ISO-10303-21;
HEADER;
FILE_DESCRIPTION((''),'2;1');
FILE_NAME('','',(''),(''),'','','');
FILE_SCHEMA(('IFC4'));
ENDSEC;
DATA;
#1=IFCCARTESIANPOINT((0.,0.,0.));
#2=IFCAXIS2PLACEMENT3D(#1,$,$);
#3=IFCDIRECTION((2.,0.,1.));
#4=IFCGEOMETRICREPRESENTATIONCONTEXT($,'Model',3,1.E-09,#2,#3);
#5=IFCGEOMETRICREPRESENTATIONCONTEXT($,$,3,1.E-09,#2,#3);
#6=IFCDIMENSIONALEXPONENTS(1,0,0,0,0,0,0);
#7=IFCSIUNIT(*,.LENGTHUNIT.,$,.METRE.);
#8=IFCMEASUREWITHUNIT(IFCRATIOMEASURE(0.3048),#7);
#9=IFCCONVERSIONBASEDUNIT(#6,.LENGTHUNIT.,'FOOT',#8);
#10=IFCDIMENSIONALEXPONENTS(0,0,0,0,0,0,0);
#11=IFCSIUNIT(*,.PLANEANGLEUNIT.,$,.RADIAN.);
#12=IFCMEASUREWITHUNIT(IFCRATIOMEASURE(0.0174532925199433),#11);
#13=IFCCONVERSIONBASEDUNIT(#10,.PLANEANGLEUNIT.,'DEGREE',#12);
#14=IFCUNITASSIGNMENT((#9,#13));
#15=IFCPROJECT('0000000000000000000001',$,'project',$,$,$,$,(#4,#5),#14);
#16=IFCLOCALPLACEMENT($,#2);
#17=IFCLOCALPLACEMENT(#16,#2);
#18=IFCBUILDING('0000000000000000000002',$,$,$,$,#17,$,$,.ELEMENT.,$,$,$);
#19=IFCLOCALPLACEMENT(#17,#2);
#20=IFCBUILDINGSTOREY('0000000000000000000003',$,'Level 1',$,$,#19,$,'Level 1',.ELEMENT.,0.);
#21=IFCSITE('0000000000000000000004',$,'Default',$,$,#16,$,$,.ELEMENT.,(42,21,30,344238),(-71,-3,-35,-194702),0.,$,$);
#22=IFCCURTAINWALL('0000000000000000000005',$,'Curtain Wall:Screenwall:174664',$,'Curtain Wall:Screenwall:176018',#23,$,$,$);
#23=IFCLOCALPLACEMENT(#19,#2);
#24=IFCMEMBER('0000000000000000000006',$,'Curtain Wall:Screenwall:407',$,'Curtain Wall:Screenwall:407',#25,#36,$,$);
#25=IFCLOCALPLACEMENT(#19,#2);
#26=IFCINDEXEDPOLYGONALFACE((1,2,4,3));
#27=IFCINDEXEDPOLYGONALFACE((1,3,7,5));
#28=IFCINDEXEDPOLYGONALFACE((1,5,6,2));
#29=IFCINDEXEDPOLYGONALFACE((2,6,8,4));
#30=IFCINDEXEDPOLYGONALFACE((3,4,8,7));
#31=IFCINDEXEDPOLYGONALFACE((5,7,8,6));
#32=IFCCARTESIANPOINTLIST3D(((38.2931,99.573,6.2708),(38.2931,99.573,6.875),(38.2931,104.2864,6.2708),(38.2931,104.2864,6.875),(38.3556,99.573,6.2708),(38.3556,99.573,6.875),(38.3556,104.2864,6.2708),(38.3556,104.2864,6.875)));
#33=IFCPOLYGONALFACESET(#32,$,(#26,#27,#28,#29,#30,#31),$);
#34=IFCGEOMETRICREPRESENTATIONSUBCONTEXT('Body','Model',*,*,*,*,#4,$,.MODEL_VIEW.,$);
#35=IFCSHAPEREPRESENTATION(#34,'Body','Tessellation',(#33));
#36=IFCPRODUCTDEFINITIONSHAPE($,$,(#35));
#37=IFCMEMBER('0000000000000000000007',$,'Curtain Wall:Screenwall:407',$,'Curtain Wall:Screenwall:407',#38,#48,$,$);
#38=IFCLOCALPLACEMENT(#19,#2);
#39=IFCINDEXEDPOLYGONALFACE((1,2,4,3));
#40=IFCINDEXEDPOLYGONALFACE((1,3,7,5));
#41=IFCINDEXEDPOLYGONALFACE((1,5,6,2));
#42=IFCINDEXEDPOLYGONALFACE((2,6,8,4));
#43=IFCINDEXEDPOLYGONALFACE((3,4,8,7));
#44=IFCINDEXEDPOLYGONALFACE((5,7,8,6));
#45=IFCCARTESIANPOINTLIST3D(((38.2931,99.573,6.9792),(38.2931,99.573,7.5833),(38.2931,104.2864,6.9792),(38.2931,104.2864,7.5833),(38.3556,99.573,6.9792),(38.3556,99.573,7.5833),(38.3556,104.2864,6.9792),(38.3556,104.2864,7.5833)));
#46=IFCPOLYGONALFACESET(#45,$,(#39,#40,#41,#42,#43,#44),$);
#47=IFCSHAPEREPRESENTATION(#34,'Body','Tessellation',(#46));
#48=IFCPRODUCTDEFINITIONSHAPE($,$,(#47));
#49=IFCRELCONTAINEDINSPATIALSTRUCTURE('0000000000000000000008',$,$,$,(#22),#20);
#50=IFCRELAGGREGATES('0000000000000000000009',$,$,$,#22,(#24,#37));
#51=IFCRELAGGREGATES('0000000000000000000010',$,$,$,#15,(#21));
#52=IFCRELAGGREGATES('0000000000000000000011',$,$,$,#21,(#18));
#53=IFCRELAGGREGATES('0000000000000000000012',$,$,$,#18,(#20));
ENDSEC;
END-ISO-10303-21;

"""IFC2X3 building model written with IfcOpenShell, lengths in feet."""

from ifc_helpers import new_model, entity, si_unit, converted_unit, direction, frame, frame_2d, origin, place, context, subcontext, project, spatial, rectangle, extrude, element, aggregate, save


model = new_model("IFC2X3")

# Units and contexts
model_context = context("Model", 3, precision=1e-09, world=origin(), true_north=direction((2.0, 0.0, 1.0)))
context_of_model = context(None, 3, precision=1e-09, world=origin(), true_north=direction((2.0, 0.0, 1.0)))
body_context = subcontext(model_context, "Body", "Model", "MODEL_VIEW")
ifc_project = project(units=[converted_unit("LENGTHUNIT", "FOOT", entity("IfcRatioMeasure", 0.3048), si_unit("LENGTHUNIT", "METRE"), dimensions=[1, 0, 0, 0, 0, 0, 0]), converted_unit("PLANEANGLEUNIT", "DEGREE", entity("IfcRatioMeasure", 0.0174532925199433), si_unit("PLANEANGLEUNIT", "RADIAN"), dimensions=[0, 0, 0, 0, 0, 0, 0])], contexts=[model_context, context_of_model])

# Site, building, storey
site_placement = place(None, origin())
site = spatial("IfcSite", under=ifc_project, at=site_placement, Name="Default", CompositionType="ELEMENT", RefLatitude=(42, 21, 30, 344238), RefLongitude=(-71, -3, -35, -194702), RefElevation=0.0)
building_placement = place(site_placement, origin())
building = spatial("IfcBuilding", under=site, at=building_placement, CompositionType="ELEMENT")
storey_placement = place(building_placement, origin())
storey = spatial("IfcBuildingStorey", under=building, at=storey_placement, Name="Level 1", LongName="Level 1", CompositionType="ELEMENT", Elevation=0.0)

# Curtain wall, members
curtain_wall_1_placement = place(storey_placement, origin())
curtain_wall_1 = element("IfcCurtainWall", 1, at=curtain_wall_1_placement, inside=storey, Name="Curtain Wall:Screenwall:174664", ObjectType="Curtain Wall:Screenwall:176018")
member_1_placement = place(curtain_wall_1_placement, frame((38.2931, 99.573, 6.2708)))
member_1 = element("IfcMember", 2, at=member_1_placement, Name="Curtain Wall:Screenwall:407", ObjectType="Curtain Wall:Screenwall:407", context=body_context, shape_type="SweptSolid", body=[
    extrude(rectangle(XDim=4.7134, YDim=0.0625, at=frame_2d((0.0, 0.0), x_axis=(1.0, 0.0))), frame((0.0312, 2.3567, 0.0), z_axis=(0.0, 0.0, 1.0), x_axis=(0.0, 1.0, 0.0)), (0.0, 0.0, 1.0), 0.6042),
])
member_2_placement = place(curtain_wall_1_placement, frame((38.2931, 99.573, 6.9792)))
member_2 = element("IfcMember", 3, at=member_2_placement, Name="Curtain Wall:Screenwall:407", ObjectType="Curtain Wall:Screenwall:407", context=body_context, shape_type="SweptSolid", body=[
    extrude(rectangle(XDim=4.7134, YDim=0.0625, at=frame_2d((0.0, 0.0), x_axis=(1.0, 0.0))), frame((0.0312, 2.3567, 0.0), z_axis=(0.0, 0.0, 1.0), x_axis=(0.0, 1.0, 0.0)), (0.0, 0.0, 1.0), 0.6042),
])
aggregate(curtain_wall_1, [member_1, member_2])

save(model, "model.ifc")
